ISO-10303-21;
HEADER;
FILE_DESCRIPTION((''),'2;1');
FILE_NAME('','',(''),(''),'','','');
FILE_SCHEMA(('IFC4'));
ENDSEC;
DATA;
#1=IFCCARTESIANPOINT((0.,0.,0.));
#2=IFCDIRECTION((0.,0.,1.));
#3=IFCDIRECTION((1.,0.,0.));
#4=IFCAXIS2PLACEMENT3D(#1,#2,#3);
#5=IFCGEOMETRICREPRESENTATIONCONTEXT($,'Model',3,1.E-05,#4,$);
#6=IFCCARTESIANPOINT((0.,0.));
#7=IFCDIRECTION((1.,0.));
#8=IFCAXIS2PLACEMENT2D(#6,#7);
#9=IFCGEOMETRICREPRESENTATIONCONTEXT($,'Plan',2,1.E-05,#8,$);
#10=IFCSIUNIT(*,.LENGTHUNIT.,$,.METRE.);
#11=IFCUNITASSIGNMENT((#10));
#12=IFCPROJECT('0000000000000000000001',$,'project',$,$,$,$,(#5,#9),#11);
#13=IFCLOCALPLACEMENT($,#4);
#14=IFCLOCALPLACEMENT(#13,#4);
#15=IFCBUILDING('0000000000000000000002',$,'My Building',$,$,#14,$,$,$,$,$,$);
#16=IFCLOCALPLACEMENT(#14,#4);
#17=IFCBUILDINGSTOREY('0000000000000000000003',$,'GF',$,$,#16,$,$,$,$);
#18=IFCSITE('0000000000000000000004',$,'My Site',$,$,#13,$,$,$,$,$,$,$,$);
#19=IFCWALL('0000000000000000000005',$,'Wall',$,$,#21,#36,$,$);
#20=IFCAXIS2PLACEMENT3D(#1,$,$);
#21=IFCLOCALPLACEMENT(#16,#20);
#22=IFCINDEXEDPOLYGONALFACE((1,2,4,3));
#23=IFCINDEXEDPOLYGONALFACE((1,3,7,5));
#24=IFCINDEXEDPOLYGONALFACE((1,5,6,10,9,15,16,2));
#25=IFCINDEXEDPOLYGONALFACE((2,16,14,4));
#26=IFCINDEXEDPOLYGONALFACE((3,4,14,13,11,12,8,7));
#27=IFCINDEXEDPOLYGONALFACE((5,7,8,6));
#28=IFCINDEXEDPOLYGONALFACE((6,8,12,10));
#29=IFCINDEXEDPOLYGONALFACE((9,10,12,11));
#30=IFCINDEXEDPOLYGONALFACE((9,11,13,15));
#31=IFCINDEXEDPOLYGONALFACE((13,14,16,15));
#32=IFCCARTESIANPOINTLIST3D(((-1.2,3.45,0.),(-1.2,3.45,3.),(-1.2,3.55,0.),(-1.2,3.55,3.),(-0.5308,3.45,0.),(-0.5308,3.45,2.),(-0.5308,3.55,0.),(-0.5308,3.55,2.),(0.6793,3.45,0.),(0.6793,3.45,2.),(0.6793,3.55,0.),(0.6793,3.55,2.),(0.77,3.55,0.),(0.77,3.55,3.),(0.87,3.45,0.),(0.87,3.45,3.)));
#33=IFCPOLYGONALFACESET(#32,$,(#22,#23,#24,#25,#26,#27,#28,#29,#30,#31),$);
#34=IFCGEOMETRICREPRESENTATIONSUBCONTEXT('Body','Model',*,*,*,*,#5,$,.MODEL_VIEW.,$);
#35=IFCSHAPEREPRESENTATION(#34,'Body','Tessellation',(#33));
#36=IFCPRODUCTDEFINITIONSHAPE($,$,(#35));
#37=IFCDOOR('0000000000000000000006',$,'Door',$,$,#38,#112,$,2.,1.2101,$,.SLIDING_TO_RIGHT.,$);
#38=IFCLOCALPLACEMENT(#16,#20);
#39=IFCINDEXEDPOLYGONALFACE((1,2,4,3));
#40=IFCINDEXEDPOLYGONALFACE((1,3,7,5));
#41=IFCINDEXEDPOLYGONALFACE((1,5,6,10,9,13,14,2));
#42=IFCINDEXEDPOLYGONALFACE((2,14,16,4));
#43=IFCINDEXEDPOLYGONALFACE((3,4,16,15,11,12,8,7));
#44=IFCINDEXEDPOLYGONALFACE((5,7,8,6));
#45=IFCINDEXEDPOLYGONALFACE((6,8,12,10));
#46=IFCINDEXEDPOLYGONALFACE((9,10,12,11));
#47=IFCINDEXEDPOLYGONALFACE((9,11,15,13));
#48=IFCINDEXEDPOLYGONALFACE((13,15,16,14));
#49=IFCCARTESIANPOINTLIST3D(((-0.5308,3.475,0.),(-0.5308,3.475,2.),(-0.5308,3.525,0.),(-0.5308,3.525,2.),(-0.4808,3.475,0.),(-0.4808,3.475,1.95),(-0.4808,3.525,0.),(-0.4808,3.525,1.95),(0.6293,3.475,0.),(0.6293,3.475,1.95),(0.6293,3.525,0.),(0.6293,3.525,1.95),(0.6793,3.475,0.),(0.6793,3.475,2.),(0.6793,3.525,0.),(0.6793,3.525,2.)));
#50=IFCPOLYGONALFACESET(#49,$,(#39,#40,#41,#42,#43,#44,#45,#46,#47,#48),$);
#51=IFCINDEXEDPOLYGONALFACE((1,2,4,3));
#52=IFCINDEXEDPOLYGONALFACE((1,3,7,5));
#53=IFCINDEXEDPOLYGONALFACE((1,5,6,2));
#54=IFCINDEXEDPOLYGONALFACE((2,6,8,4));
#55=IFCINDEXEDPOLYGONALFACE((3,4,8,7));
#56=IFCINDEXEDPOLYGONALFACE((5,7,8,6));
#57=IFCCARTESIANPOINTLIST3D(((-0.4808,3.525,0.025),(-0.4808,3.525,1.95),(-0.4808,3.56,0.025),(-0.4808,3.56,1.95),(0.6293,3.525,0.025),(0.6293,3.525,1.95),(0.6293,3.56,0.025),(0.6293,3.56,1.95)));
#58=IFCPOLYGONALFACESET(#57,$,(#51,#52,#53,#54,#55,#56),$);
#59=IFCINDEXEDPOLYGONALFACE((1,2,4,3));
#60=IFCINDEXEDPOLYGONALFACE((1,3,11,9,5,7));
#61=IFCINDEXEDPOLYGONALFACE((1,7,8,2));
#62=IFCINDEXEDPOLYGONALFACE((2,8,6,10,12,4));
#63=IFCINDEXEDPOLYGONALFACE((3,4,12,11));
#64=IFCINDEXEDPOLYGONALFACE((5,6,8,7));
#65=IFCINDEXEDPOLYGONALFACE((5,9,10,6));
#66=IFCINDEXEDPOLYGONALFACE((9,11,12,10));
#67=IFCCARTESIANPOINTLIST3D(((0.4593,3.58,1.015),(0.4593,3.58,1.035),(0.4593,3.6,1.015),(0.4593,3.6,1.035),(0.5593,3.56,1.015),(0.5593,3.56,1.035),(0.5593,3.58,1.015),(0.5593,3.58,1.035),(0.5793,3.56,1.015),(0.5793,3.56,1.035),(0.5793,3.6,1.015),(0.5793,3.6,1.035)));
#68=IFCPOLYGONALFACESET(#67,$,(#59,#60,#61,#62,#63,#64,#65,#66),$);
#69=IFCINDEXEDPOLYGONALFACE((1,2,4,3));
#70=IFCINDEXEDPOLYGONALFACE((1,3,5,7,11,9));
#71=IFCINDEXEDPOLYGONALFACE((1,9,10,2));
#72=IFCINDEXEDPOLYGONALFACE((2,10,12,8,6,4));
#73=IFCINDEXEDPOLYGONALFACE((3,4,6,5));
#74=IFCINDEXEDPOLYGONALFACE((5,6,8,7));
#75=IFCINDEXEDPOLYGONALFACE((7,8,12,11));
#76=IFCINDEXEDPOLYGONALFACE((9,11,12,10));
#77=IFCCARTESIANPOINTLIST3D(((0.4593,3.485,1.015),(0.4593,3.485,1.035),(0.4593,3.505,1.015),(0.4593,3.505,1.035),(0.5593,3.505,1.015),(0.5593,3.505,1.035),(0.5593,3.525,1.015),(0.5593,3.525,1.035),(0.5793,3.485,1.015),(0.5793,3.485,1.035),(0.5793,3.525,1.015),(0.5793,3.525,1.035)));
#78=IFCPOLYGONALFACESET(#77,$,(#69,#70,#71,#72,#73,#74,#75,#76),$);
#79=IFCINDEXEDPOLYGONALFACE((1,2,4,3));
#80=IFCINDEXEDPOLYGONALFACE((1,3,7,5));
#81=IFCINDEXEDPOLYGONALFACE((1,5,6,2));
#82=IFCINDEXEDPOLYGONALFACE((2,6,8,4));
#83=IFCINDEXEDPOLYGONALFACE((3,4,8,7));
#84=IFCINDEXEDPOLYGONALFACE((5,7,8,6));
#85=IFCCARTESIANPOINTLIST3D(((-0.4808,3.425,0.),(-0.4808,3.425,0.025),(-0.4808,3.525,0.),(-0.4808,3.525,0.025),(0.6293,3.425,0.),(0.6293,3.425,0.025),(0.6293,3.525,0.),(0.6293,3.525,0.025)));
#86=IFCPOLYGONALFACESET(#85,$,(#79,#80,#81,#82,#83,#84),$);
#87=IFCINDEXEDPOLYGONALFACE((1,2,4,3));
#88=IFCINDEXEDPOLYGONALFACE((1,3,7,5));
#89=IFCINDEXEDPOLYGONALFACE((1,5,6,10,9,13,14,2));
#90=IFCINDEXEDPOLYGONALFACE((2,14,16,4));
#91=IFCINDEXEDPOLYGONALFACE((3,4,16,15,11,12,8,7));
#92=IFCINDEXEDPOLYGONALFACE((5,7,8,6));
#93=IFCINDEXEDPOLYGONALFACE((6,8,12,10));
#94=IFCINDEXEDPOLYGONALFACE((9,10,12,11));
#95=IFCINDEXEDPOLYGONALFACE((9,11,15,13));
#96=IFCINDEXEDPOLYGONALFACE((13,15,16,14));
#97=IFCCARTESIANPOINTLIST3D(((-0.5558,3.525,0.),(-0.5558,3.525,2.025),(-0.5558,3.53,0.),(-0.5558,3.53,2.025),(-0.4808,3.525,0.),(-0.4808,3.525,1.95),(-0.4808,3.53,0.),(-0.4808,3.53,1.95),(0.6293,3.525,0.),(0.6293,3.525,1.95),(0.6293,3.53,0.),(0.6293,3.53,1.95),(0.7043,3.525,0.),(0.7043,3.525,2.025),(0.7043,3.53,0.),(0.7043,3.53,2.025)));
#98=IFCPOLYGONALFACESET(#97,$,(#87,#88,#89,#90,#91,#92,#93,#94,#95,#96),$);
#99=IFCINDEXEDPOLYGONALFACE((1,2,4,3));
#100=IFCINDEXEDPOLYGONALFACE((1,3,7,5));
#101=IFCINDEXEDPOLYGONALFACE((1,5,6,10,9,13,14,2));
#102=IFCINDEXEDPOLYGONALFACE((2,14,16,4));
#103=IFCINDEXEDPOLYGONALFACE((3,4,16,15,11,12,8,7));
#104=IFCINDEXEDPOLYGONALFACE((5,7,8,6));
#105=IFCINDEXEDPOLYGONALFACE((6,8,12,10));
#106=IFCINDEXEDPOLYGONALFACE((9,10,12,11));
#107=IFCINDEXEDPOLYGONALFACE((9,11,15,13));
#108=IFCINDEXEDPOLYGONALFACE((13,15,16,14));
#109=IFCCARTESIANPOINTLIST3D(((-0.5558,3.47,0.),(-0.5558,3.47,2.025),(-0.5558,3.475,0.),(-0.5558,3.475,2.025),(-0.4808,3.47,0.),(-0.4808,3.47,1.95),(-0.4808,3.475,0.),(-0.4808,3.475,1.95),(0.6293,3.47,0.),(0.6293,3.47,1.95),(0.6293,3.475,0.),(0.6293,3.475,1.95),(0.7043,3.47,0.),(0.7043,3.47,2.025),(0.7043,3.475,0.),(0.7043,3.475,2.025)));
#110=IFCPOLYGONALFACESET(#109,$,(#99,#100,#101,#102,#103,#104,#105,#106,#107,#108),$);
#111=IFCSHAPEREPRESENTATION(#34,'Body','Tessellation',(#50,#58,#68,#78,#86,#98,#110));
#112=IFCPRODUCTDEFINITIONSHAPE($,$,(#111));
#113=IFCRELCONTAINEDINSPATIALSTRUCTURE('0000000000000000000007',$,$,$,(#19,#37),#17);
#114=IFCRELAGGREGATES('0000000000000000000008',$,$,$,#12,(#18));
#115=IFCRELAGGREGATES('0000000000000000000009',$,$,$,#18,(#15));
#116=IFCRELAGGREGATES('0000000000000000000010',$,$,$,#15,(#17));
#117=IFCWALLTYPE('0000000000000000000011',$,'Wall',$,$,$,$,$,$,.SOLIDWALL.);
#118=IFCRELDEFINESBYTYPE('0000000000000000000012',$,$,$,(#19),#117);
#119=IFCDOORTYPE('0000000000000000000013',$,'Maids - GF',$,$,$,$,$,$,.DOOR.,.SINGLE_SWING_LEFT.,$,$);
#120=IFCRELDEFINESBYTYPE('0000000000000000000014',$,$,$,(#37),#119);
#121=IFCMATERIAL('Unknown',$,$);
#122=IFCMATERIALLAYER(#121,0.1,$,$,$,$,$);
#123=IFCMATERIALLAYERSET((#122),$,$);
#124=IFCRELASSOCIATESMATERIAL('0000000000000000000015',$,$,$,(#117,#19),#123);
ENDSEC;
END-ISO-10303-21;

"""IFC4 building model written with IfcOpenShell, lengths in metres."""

from ifc_helpers import new_model, entity, si_unit, frame, origin_with_axes, origin_2d_with_axis, place, context, subcontext, project, spatial, line, indexed_curve, outline, extrude, shape, source, transform, mapped, material, layer, layer_set, layer_usage, type_object, type_shapes, element, fill, save


model = new_model("IFC4")

# Units and contexts
model_context = context("Model", 3, precision=1e-05, world=origin_with_axes())
plan_context = context("Plan", 2, precision=1e-05, world=origin_2d_with_axis())
body_context_1 = subcontext(model_context, "Body", "Model", "MODEL_VIEW")
body_context_2 = subcontext(plan_context, "Body", "Plan", "PLAN_VIEW")
ifc_project = project(units=[si_unit("LENGTHUNIT", "METRE")], contexts=[model_context, plan_context])

# Site, building, storey
site_placement = place(None, origin_with_axes())
site = spatial("IfcSite", under=ifc_project, at=site_placement, Name="My Site")
building_placement = place(site_placement, origin_with_axes())
building = spatial("IfcBuilding", under=site, at=building_placement, Name="My Building")
storey_placement = place(building_placement, origin_with_axes())
storey = spatial("IfcBuildingStorey", under=building, at=storey_placement, Name="GF")

# Shared definitions
ifc_material_1 = material(Name="Unknown")

# Shared definitions
ifc_layer_1 = layer(ifc_material_1, 0.1)
ifc_layer_set_1 = layer_set([ifc_layer_1])
wall_type = type_object("IfcWallType", Name="Wall", PredefinedType="SOLIDWALL", material=ifc_layer_set_1)

# Wall, opening, door
ifc_layer_usage_1 = layer_usage(ifc_layer_set_1, "AXIS2", "POSITIVE", 0.0)
wall_1_placement = place(storey_placement, frame((0.77, 3.55, 0.0), z_axis=(0.0, 0.0, 1.0), x_axis=(-1.0, 0.0, 0.0)))
wall_1 = element("IfcWall", 1, at=wall_1_placement, inside=storey, type_object=wall_type, material=ifc_layer_usage_1, Name="Wall", context=body_context_1, shape_type="SweptSolid", body=[
    extrude(outline(indexed_curve([(0.0, 0.0), (-0.1, 0.1), (1.97, 0.1), (1.97, 0.0)], segments=[line(1, 2, 3, 4, 1)])), origin_with_axes(), (0.0, 0.0, 1.0), 3.0),
])
shared_shape_1 = source(origin_with_axes(), body_context_1, "Body", "SweptSolid", [
    extrude(outline(indexed_curve([(0.0, 0.0), (1.2101, 0.0), (1.2101, 2.0), (0.0, 2.0)], segments=[line(1, 2, 3, 4, 1)])), frame((0.0, -0.6, 0.0), z_axis=(0.0, -1.0, 0.0), x_axis=(1.0, 0.0, 0.0)), (0.0, 0.0, -1.0), 1.2),
])
opening_1_placement = place(wall_1_placement, frame((0.0907, 0.025, 0.0), z_axis=(0.0, 0.0, 1.0), x_axis=(1.0, 0.0, 0.0)))
opening_1 = element("IfcOpeningElement", 2, at=opening_1_placement, cuts=wall_1, PredefinedType="OPENING", context=body_context_1, shape_type="MappedRepresentation", body=[
    mapped(shared_shape_1, transform((0.0, 0.0, 0.0), x_axis=(1.0, 0.0, 0.0), y_axis=(0.0, 1.0, 0.0), z_axis=(0.0, 0.0, 1.0), scale=1.0)),
])
door_type_1 = type_object("IfcDoorType", Name="Maids - GF", OperationType="SINGLE_SWING_LEFT", PredefinedType="DOOR")
shared_shape_2 = source(origin_with_axes(), body_context_1, "Body", "SweptSolid", [
    extrude(outline(indexed_curve([(0.0, 0.0), (0.0, 2.0), (1.2101, 2.0), (1.2101, 0.0), (1.1601, 0.0), (1.1601, 1.95), (0.05, 1.95), (0.05, 0.0)], segments=[line(1, 2, 3, 4, 5, 6, 7, 8, 1)])), frame((0.0, 0.0, 0.0), z_axis=(0.0, -1.0, 0.0), x_axis=(1.0, 0.0, 0.0)), (0.0, 0.0, -1.0), 0.05),
    extrude(outline(indexed_curve([(0.0, 0.0), (1.1101, 0.0), (1.1101, 0.035), (0.0, 0.035)], segments=[line(1, 2, 3, 4, 1)])), frame((0.05, -0.035, 0.025), z_axis=(0.0, 0.0, 1.0), x_axis=(1.0, 0.0, 0.0)), (0.0, 0.0, 1.0), 1.925),
    extrude(outline(indexed_curve([(0.0, 0.0), (0.0, -0.04), (0.12, -0.04), (0.12, -0.02), (0.02, -0.02), (0.02, 0.0)], segments=[line(1, 2, 3, 4, 5, 6, 1)])), frame((0.1, -0.035, 1.015), z_axis=(0.0, 0.0, 1.0), x_axis=(1.0, 0.0, 0.0)), (0.0, 0.0, 1.0), 0.02),
    extrude(outline(indexed_curve([(0.0, 0.0), (0.0, 0.04), (0.12, 0.04), (0.12, 0.02), (0.02, 0.02), (0.02, 0.0)], segments=[line(1, 2, 3, 4, 5, 6, 1)])), frame((0.1, 0.0, 1.015), z_axis=(0.0, 0.0, 1.0), x_axis=(1.0, 0.0, 0.0)), (0.0, 0.0, 1.0), 0.02),
    extrude(outline(indexed_curve([(0.0, 0.0), (1.1101, 0.0), (1.1101, 0.1), (0.0, 0.1)], segments=[line(1, 2, 3, 4, 1)])), frame((0.05, 0.0, 0.0), z_axis=(0.0, 0.0, 1.0), x_axis=(1.0, 0.0, 0.0)), (0.0, 0.0, 1.0), 0.025),
    extrude(outline(indexed_curve([(0.0, 0.0), (0.0, 2.025), (1.2601, 2.025), (1.2601, 0.0), (1.1851, 0.0), (1.1851, 1.95), (0.075, 1.95), (0.075, 0.0)], segments=[line(1, 2, 3, 4, 5, 6, 7, 8, 1)])), frame((-0.025, -0.005, 0.0), z_axis=(0.0, -1.0, 0.0), x_axis=(1.0, 0.0, 0.0)), (0.0, 0.0, -1.0), 0.005),
    extrude(outline(indexed_curve([(0.0, 0.0), (0.0, 2.025), (1.2601, 2.025), (1.2601, 0.0), (1.1851, 0.0), (1.1851, 1.95), (0.075, 1.95), (0.075, 0.0)], segments=[line(1, 2, 3, 4, 5, 6, 7, 8, 1)])), frame((-0.025, 0.05, 0.0), z_axis=(0.0, -1.0, 0.0), x_axis=(1.0, 0.0, 0.0)), (0.0, 0.0, -1.0), 0.005),
])
shared_shape_3 = source(origin_with_axes(), body_context_2, "Body", "Curve2D", [
    entity("IfcIndexedPolyCurve", entity("IfcCartesianPointList2D", [[0.0, 0.0], [0.05, 0.0], [0.05, 0.05], [0.0, 0.05]]), [entity("IfcLineIndex", [1, 2, 3, 4, 1])]),
    entity("IfcIndexedPolyCurve", entity("IfcCartesianPointList2D", [[1.2101, 0.0], [1.1601, 0.0], [1.1601, 0.05], [1.2101, 0.05]]), [entity("IfcLineIndex", [1, 2, 3, 4, 1])]),
    entity("IfcIndexedPolyCurve", entity("IfcCartesianPointList2D", [[1.7151, -0.035], [0.605, -0.035], [0.605, 0.0], [1.7151, 0.0]]), [entity("IfcLineIndex", [1, 2, 3, 4, 1])]),
])
type_shapes(door_type_1, [shared_shape_2, shared_shape_3])
door_1_placement = place(opening_1_placement, frame((0.0, 0.0, 0.0), z_axis=(0.0, 0.0, 1.0), x_axis=(1.0, 0.0, 0.0)))
door_1 = element("IfcDoor", 3, at=door_1_placement, inside=storey, type_object=door_type_1, Name="Door", OperationType="SLIDING_TO_RIGHT", OverallHeight=2.0, OverallWidth=1.2101, shapes=[
    shape(body_context_1, "Body", "MappedRepresentation", [mapped(shared_shape_2, transform((0.0, 0.0, 0.0), x_axis=(1.0, 0.0, 0.0), y_axis=(0.0, 1.0, 0.0), z_axis=(0.0, 0.0, 1.0), scale=1.0))]),
    shape(body_context_2, "Body", "MappedRepresentation", [mapped(shared_shape_3, transform((0.0, 0.0, 0.0), x_axis=(1.0, 0.0, 0.0), y_axis=(0.0, 1.0, 0.0), z_axis=(0.0, 0.0, 1.0), scale=1.0))]),
])
fill(opening_1, door_1)

save(model, "model.ifc")
